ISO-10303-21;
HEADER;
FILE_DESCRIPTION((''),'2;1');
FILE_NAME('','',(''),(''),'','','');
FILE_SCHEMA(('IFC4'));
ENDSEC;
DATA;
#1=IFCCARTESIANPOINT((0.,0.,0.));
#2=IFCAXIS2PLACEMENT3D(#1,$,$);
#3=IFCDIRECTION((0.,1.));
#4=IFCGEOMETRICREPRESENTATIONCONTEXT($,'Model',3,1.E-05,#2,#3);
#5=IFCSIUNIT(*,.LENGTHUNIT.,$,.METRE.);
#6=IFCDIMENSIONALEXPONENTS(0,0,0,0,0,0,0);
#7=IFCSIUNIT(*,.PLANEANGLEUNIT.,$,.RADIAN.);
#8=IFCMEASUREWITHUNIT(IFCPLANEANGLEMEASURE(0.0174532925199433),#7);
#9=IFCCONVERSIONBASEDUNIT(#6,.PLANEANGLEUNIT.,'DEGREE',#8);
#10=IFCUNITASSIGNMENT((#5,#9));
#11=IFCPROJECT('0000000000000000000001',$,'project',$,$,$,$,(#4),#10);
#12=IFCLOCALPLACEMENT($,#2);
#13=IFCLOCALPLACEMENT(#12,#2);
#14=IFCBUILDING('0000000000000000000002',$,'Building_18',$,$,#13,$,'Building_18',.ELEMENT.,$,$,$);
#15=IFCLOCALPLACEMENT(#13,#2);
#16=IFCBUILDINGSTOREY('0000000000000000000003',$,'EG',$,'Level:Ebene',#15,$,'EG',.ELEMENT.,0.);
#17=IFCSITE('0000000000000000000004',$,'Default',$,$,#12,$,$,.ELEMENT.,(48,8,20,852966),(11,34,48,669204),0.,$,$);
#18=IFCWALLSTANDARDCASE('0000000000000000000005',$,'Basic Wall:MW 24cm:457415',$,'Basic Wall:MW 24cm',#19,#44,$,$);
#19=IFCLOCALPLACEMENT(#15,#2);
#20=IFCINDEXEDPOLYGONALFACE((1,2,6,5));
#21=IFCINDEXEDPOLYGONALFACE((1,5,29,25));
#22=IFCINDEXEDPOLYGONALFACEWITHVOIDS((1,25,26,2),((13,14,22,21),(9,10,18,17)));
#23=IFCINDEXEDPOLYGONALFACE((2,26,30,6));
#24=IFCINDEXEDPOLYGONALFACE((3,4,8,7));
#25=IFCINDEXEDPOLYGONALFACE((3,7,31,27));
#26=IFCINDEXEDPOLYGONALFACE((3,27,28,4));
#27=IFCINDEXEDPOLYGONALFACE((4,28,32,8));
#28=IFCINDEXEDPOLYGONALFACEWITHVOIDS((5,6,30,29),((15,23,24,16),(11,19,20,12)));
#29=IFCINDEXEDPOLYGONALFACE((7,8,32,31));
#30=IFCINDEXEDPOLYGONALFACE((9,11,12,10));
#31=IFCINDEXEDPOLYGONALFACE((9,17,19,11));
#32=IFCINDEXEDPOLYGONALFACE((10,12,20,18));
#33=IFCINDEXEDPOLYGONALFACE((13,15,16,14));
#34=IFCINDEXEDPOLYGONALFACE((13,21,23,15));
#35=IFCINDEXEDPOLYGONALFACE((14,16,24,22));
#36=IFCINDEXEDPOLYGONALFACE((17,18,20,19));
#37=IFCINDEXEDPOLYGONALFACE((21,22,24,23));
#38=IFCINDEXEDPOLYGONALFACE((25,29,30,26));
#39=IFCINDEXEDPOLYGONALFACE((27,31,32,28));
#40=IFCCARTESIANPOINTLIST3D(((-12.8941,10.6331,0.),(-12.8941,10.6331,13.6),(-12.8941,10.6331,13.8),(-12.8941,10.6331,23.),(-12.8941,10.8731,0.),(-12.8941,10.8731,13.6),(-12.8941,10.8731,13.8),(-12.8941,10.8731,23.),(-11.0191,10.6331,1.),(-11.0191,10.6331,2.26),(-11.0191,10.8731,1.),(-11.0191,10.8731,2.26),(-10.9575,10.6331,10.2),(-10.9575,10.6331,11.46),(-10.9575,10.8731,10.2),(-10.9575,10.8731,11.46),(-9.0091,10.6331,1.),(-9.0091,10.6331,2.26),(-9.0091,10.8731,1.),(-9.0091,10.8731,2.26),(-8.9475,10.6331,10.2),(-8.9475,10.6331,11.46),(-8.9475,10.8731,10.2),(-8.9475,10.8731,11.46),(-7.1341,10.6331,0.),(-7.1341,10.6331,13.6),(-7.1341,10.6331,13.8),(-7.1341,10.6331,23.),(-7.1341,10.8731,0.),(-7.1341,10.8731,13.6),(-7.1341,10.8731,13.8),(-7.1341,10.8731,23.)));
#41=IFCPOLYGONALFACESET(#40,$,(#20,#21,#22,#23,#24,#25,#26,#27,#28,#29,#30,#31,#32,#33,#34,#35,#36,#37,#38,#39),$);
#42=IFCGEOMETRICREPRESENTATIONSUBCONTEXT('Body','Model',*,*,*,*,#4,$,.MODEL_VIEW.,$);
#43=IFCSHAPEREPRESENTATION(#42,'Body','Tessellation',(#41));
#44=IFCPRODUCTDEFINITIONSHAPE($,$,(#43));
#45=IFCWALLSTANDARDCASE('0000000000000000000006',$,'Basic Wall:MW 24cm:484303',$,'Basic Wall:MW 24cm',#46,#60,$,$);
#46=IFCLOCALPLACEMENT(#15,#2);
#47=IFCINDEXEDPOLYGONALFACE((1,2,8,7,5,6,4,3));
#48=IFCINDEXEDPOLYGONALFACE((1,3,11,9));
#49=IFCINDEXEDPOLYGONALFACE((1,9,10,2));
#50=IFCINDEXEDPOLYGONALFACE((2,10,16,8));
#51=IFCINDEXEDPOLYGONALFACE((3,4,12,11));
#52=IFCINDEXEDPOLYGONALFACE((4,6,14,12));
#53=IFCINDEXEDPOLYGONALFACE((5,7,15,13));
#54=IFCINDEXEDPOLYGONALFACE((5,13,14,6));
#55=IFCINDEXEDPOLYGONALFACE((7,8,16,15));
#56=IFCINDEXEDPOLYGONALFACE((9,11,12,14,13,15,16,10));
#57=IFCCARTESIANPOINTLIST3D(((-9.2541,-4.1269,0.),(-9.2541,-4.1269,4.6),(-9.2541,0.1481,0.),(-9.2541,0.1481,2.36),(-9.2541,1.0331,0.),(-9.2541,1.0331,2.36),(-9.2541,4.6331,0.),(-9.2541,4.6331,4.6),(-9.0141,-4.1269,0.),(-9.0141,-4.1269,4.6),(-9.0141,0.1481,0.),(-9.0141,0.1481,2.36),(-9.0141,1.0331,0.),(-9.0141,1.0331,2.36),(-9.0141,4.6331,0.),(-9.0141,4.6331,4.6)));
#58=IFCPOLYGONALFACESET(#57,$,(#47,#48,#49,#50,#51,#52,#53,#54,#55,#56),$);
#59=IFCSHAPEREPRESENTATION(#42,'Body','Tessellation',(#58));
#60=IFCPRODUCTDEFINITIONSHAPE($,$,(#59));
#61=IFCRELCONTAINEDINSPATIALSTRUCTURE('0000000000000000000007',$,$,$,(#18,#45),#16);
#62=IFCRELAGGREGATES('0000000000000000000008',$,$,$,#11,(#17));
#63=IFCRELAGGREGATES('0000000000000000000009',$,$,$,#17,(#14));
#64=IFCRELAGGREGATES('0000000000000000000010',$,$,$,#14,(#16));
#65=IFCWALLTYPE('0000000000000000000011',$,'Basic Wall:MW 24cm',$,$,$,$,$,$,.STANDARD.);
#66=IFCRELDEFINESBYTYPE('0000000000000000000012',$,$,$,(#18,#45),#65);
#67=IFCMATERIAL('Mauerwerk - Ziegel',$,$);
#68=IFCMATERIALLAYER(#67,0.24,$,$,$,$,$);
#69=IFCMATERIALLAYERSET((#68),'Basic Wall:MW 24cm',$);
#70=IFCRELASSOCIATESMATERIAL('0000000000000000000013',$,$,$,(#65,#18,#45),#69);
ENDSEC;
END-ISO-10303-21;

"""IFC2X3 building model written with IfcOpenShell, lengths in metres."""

from ifc_helpers import new_model, entity, si_unit, converted_unit, direction, frame, frame_2d, origin, place, context, subcontext, project, spatial, rectangle, extrude, material, layer, layer_set, layer_usage, type_object, element, save


model = new_model("IFC2X3")

# Units and contexts
model_context = context("Model", 3, precision=1e-05, world=origin(), true_north=direction((0.0, 1.0)))
body_context = subcontext(model_context, "Body", "Model", "MODEL_VIEW")
ifc_project = project(units=[si_unit("LENGTHUNIT", "METRE"), converted_unit("PLANEANGLEUNIT", "DEGREE", entity("IfcPlaneAngleMeasure", 0.0174532925199433), si_unit("PLANEANGLEUNIT", "RADIAN"), dimensions=[0, 0, 0, 0, 0, 0, 0])], contexts=[model_context])

# Site, building, storey
site_placement = place(None, origin())
site = spatial("IfcSite", under=ifc_project, at=site_placement, Name="Default", CompositionType="ELEMENT", RefLatitude=(48, 8, 20, 852966), RefLongitude=(11, 34, 48, 669204), RefElevation=0.0)
building_placement = place(site_placement, origin())
building = spatial("IfcBuilding", under=site, at=building_placement, Name="Building_18", LongName="Building_18", CompositionType="ELEMENT")
storey_placement = place(building_placement, origin())
storey = spatial("IfcBuildingStorey", under=building, at=storey_placement, Name="EG", ObjectType="Level:Ebene", LongName="EG", CompositionType="ELEMENT", Elevation=0.0)

# Wall, openings
ifc_material_1 = material(Name="Mauerwerk - Ziegel")
ifc_layer_1 = layer(ifc_material_1, 0.24)
ifc_layer_set_1 = layer_set([ifc_layer_1], Name="Basic Wall:MW 24cm")
wall_type = type_object("IfcWallType", Name="Basic Wall:MW 24cm", PredefinedType="STANDARD", material=ifc_layer_set_1)
ifc_layer_usage_1 = layer_usage(ifc_layer_set_1, "AXIS2", "NEGATIVE", 0.12)
wall_1_placement = place(storey_placement, frame((-7.1341, 10.7531, 0.0), z_axis=(0.0, 0.0, 1.0), x_axis=(-1.0, 0.0, 0.0)))
wall_1 = element("IfcWallStandardCase", 1, at=wall_1_placement, inside=storey, type_object=wall_type, material=ifc_layer_usage_1, Name="Basic Wall:MW 24cm:457415", ObjectType="Basic Wall:MW 24cm", context=body_context, shape_type="SweptSolid", body=[
    extrude(rectangle(XDim=5.76, YDim=0.24, at=frame_2d((2.88, 0.0), x_axis=(-1.0, 0.0))), origin(), (0.0, 0.0, 1.0), 23.0),
])
opening_1_placement = place(storey_placement, frame((-7.1341, 10.7531, 0.0), z_axis=(0.0, 0.0, 1.0), x_axis=(-1.0, 0.0, 0.0)))
element("IfcOpeningElement", 2, at=opening_1_placement, cuts=wall_1, ObjectType="Opening", context=body_context, shape_type="SweptSolid", body=[
    extrude(rectangle(XDim=5.76, YDim=0.24, at=frame_2d((0.0, 0.0), x_axis=(1.0, 0.0))), frame((2.88, 0.0, 13.6)), (0.0, 0.0, 1.0), 0.2),
])
opening_2_placement = place(wall_1_placement, frame((3.885, 0.12, 1.0)))
element("IfcOpeningElement", 3, at=opening_2_placement, cuts=wall_1, ObjectType="Opening", context=body_context, shape_type="SweptSolid", body=[
    extrude(rectangle(XDim=1.26, YDim=2.01, at=frame_2d((0.63, 1.005), x_axis=(1.0, 0.0))), frame((0.0, 0.0, 0.0), z_axis=(0.0, -1.0, 0.0), x_axis=(0.0, 0.0, 1.0)), (0.0, 0.0, 1.0), 0.24),
])
opening_3_placement = place(wall_1_placement, frame((3.8235, 0.12, 10.2)))
element("IfcOpeningElement", 4, at=opening_3_placement, cuts=wall_1, ObjectType="Opening", context=body_context, shape_type="SweptSolid", body=[
    extrude(rectangle(XDim=1.26, YDim=2.01, at=frame_2d((0.63, 1.005), x_axis=(1.0, 0.0))), frame((0.0, 0.0, 0.0), z_axis=(0.0, -1.0, 0.0), x_axis=(0.0, 0.0, 1.0)), (0.0, 0.0, 1.0), 0.24),
])

# Wall, opening
ifc_layer_usage_2 = layer_usage(ifc_layer_set_1, "AXIS2", "NEGATIVE", 0.12)
wall_2_placement = place(storey_placement, frame((-9.1341, 4.6331, 0.0), z_axis=(0.0, 0.0, 1.0), x_axis=(0.0, -1.0, 0.0)))
wall_2 = element("IfcWallStandardCase", 5, at=wall_2_placement, inside=storey, type_object=wall_type, material=ifc_layer_usage_2, Name="Basic Wall:MW 24cm:484303", ObjectType="Basic Wall:MW 24cm", context=body_context, shape_type="SweptSolid", body=[
    extrude(rectangle(XDim=8.76, YDim=0.24, at=frame_2d((4.38, 0.0), x_axis=(-1.0, 0.0))), origin(), (0.0, 0.0, 1.0), 4.6),
])
opening_4_placement = place(wall_2_placement, frame((4.485, 0.12, 0.0)))
element("IfcOpeningElement", 6, at=opening_4_placement, cuts=wall_2, ObjectType="Opening", context=body_context, shape_type="SweptSolid", body=[
    extrude(rectangle(XDim=2.36, YDim=0.885, at=frame_2d((1.18, 0.4425), x_axis=(1.0, 0.0))), frame((0.0, 0.0, 0.0), z_axis=(0.0, -1.0, 0.0), x_axis=(0.0, 0.0, 1.0)), (0.0, 0.0, 1.0), 0.24),
])

save(model, "model.ifc")
